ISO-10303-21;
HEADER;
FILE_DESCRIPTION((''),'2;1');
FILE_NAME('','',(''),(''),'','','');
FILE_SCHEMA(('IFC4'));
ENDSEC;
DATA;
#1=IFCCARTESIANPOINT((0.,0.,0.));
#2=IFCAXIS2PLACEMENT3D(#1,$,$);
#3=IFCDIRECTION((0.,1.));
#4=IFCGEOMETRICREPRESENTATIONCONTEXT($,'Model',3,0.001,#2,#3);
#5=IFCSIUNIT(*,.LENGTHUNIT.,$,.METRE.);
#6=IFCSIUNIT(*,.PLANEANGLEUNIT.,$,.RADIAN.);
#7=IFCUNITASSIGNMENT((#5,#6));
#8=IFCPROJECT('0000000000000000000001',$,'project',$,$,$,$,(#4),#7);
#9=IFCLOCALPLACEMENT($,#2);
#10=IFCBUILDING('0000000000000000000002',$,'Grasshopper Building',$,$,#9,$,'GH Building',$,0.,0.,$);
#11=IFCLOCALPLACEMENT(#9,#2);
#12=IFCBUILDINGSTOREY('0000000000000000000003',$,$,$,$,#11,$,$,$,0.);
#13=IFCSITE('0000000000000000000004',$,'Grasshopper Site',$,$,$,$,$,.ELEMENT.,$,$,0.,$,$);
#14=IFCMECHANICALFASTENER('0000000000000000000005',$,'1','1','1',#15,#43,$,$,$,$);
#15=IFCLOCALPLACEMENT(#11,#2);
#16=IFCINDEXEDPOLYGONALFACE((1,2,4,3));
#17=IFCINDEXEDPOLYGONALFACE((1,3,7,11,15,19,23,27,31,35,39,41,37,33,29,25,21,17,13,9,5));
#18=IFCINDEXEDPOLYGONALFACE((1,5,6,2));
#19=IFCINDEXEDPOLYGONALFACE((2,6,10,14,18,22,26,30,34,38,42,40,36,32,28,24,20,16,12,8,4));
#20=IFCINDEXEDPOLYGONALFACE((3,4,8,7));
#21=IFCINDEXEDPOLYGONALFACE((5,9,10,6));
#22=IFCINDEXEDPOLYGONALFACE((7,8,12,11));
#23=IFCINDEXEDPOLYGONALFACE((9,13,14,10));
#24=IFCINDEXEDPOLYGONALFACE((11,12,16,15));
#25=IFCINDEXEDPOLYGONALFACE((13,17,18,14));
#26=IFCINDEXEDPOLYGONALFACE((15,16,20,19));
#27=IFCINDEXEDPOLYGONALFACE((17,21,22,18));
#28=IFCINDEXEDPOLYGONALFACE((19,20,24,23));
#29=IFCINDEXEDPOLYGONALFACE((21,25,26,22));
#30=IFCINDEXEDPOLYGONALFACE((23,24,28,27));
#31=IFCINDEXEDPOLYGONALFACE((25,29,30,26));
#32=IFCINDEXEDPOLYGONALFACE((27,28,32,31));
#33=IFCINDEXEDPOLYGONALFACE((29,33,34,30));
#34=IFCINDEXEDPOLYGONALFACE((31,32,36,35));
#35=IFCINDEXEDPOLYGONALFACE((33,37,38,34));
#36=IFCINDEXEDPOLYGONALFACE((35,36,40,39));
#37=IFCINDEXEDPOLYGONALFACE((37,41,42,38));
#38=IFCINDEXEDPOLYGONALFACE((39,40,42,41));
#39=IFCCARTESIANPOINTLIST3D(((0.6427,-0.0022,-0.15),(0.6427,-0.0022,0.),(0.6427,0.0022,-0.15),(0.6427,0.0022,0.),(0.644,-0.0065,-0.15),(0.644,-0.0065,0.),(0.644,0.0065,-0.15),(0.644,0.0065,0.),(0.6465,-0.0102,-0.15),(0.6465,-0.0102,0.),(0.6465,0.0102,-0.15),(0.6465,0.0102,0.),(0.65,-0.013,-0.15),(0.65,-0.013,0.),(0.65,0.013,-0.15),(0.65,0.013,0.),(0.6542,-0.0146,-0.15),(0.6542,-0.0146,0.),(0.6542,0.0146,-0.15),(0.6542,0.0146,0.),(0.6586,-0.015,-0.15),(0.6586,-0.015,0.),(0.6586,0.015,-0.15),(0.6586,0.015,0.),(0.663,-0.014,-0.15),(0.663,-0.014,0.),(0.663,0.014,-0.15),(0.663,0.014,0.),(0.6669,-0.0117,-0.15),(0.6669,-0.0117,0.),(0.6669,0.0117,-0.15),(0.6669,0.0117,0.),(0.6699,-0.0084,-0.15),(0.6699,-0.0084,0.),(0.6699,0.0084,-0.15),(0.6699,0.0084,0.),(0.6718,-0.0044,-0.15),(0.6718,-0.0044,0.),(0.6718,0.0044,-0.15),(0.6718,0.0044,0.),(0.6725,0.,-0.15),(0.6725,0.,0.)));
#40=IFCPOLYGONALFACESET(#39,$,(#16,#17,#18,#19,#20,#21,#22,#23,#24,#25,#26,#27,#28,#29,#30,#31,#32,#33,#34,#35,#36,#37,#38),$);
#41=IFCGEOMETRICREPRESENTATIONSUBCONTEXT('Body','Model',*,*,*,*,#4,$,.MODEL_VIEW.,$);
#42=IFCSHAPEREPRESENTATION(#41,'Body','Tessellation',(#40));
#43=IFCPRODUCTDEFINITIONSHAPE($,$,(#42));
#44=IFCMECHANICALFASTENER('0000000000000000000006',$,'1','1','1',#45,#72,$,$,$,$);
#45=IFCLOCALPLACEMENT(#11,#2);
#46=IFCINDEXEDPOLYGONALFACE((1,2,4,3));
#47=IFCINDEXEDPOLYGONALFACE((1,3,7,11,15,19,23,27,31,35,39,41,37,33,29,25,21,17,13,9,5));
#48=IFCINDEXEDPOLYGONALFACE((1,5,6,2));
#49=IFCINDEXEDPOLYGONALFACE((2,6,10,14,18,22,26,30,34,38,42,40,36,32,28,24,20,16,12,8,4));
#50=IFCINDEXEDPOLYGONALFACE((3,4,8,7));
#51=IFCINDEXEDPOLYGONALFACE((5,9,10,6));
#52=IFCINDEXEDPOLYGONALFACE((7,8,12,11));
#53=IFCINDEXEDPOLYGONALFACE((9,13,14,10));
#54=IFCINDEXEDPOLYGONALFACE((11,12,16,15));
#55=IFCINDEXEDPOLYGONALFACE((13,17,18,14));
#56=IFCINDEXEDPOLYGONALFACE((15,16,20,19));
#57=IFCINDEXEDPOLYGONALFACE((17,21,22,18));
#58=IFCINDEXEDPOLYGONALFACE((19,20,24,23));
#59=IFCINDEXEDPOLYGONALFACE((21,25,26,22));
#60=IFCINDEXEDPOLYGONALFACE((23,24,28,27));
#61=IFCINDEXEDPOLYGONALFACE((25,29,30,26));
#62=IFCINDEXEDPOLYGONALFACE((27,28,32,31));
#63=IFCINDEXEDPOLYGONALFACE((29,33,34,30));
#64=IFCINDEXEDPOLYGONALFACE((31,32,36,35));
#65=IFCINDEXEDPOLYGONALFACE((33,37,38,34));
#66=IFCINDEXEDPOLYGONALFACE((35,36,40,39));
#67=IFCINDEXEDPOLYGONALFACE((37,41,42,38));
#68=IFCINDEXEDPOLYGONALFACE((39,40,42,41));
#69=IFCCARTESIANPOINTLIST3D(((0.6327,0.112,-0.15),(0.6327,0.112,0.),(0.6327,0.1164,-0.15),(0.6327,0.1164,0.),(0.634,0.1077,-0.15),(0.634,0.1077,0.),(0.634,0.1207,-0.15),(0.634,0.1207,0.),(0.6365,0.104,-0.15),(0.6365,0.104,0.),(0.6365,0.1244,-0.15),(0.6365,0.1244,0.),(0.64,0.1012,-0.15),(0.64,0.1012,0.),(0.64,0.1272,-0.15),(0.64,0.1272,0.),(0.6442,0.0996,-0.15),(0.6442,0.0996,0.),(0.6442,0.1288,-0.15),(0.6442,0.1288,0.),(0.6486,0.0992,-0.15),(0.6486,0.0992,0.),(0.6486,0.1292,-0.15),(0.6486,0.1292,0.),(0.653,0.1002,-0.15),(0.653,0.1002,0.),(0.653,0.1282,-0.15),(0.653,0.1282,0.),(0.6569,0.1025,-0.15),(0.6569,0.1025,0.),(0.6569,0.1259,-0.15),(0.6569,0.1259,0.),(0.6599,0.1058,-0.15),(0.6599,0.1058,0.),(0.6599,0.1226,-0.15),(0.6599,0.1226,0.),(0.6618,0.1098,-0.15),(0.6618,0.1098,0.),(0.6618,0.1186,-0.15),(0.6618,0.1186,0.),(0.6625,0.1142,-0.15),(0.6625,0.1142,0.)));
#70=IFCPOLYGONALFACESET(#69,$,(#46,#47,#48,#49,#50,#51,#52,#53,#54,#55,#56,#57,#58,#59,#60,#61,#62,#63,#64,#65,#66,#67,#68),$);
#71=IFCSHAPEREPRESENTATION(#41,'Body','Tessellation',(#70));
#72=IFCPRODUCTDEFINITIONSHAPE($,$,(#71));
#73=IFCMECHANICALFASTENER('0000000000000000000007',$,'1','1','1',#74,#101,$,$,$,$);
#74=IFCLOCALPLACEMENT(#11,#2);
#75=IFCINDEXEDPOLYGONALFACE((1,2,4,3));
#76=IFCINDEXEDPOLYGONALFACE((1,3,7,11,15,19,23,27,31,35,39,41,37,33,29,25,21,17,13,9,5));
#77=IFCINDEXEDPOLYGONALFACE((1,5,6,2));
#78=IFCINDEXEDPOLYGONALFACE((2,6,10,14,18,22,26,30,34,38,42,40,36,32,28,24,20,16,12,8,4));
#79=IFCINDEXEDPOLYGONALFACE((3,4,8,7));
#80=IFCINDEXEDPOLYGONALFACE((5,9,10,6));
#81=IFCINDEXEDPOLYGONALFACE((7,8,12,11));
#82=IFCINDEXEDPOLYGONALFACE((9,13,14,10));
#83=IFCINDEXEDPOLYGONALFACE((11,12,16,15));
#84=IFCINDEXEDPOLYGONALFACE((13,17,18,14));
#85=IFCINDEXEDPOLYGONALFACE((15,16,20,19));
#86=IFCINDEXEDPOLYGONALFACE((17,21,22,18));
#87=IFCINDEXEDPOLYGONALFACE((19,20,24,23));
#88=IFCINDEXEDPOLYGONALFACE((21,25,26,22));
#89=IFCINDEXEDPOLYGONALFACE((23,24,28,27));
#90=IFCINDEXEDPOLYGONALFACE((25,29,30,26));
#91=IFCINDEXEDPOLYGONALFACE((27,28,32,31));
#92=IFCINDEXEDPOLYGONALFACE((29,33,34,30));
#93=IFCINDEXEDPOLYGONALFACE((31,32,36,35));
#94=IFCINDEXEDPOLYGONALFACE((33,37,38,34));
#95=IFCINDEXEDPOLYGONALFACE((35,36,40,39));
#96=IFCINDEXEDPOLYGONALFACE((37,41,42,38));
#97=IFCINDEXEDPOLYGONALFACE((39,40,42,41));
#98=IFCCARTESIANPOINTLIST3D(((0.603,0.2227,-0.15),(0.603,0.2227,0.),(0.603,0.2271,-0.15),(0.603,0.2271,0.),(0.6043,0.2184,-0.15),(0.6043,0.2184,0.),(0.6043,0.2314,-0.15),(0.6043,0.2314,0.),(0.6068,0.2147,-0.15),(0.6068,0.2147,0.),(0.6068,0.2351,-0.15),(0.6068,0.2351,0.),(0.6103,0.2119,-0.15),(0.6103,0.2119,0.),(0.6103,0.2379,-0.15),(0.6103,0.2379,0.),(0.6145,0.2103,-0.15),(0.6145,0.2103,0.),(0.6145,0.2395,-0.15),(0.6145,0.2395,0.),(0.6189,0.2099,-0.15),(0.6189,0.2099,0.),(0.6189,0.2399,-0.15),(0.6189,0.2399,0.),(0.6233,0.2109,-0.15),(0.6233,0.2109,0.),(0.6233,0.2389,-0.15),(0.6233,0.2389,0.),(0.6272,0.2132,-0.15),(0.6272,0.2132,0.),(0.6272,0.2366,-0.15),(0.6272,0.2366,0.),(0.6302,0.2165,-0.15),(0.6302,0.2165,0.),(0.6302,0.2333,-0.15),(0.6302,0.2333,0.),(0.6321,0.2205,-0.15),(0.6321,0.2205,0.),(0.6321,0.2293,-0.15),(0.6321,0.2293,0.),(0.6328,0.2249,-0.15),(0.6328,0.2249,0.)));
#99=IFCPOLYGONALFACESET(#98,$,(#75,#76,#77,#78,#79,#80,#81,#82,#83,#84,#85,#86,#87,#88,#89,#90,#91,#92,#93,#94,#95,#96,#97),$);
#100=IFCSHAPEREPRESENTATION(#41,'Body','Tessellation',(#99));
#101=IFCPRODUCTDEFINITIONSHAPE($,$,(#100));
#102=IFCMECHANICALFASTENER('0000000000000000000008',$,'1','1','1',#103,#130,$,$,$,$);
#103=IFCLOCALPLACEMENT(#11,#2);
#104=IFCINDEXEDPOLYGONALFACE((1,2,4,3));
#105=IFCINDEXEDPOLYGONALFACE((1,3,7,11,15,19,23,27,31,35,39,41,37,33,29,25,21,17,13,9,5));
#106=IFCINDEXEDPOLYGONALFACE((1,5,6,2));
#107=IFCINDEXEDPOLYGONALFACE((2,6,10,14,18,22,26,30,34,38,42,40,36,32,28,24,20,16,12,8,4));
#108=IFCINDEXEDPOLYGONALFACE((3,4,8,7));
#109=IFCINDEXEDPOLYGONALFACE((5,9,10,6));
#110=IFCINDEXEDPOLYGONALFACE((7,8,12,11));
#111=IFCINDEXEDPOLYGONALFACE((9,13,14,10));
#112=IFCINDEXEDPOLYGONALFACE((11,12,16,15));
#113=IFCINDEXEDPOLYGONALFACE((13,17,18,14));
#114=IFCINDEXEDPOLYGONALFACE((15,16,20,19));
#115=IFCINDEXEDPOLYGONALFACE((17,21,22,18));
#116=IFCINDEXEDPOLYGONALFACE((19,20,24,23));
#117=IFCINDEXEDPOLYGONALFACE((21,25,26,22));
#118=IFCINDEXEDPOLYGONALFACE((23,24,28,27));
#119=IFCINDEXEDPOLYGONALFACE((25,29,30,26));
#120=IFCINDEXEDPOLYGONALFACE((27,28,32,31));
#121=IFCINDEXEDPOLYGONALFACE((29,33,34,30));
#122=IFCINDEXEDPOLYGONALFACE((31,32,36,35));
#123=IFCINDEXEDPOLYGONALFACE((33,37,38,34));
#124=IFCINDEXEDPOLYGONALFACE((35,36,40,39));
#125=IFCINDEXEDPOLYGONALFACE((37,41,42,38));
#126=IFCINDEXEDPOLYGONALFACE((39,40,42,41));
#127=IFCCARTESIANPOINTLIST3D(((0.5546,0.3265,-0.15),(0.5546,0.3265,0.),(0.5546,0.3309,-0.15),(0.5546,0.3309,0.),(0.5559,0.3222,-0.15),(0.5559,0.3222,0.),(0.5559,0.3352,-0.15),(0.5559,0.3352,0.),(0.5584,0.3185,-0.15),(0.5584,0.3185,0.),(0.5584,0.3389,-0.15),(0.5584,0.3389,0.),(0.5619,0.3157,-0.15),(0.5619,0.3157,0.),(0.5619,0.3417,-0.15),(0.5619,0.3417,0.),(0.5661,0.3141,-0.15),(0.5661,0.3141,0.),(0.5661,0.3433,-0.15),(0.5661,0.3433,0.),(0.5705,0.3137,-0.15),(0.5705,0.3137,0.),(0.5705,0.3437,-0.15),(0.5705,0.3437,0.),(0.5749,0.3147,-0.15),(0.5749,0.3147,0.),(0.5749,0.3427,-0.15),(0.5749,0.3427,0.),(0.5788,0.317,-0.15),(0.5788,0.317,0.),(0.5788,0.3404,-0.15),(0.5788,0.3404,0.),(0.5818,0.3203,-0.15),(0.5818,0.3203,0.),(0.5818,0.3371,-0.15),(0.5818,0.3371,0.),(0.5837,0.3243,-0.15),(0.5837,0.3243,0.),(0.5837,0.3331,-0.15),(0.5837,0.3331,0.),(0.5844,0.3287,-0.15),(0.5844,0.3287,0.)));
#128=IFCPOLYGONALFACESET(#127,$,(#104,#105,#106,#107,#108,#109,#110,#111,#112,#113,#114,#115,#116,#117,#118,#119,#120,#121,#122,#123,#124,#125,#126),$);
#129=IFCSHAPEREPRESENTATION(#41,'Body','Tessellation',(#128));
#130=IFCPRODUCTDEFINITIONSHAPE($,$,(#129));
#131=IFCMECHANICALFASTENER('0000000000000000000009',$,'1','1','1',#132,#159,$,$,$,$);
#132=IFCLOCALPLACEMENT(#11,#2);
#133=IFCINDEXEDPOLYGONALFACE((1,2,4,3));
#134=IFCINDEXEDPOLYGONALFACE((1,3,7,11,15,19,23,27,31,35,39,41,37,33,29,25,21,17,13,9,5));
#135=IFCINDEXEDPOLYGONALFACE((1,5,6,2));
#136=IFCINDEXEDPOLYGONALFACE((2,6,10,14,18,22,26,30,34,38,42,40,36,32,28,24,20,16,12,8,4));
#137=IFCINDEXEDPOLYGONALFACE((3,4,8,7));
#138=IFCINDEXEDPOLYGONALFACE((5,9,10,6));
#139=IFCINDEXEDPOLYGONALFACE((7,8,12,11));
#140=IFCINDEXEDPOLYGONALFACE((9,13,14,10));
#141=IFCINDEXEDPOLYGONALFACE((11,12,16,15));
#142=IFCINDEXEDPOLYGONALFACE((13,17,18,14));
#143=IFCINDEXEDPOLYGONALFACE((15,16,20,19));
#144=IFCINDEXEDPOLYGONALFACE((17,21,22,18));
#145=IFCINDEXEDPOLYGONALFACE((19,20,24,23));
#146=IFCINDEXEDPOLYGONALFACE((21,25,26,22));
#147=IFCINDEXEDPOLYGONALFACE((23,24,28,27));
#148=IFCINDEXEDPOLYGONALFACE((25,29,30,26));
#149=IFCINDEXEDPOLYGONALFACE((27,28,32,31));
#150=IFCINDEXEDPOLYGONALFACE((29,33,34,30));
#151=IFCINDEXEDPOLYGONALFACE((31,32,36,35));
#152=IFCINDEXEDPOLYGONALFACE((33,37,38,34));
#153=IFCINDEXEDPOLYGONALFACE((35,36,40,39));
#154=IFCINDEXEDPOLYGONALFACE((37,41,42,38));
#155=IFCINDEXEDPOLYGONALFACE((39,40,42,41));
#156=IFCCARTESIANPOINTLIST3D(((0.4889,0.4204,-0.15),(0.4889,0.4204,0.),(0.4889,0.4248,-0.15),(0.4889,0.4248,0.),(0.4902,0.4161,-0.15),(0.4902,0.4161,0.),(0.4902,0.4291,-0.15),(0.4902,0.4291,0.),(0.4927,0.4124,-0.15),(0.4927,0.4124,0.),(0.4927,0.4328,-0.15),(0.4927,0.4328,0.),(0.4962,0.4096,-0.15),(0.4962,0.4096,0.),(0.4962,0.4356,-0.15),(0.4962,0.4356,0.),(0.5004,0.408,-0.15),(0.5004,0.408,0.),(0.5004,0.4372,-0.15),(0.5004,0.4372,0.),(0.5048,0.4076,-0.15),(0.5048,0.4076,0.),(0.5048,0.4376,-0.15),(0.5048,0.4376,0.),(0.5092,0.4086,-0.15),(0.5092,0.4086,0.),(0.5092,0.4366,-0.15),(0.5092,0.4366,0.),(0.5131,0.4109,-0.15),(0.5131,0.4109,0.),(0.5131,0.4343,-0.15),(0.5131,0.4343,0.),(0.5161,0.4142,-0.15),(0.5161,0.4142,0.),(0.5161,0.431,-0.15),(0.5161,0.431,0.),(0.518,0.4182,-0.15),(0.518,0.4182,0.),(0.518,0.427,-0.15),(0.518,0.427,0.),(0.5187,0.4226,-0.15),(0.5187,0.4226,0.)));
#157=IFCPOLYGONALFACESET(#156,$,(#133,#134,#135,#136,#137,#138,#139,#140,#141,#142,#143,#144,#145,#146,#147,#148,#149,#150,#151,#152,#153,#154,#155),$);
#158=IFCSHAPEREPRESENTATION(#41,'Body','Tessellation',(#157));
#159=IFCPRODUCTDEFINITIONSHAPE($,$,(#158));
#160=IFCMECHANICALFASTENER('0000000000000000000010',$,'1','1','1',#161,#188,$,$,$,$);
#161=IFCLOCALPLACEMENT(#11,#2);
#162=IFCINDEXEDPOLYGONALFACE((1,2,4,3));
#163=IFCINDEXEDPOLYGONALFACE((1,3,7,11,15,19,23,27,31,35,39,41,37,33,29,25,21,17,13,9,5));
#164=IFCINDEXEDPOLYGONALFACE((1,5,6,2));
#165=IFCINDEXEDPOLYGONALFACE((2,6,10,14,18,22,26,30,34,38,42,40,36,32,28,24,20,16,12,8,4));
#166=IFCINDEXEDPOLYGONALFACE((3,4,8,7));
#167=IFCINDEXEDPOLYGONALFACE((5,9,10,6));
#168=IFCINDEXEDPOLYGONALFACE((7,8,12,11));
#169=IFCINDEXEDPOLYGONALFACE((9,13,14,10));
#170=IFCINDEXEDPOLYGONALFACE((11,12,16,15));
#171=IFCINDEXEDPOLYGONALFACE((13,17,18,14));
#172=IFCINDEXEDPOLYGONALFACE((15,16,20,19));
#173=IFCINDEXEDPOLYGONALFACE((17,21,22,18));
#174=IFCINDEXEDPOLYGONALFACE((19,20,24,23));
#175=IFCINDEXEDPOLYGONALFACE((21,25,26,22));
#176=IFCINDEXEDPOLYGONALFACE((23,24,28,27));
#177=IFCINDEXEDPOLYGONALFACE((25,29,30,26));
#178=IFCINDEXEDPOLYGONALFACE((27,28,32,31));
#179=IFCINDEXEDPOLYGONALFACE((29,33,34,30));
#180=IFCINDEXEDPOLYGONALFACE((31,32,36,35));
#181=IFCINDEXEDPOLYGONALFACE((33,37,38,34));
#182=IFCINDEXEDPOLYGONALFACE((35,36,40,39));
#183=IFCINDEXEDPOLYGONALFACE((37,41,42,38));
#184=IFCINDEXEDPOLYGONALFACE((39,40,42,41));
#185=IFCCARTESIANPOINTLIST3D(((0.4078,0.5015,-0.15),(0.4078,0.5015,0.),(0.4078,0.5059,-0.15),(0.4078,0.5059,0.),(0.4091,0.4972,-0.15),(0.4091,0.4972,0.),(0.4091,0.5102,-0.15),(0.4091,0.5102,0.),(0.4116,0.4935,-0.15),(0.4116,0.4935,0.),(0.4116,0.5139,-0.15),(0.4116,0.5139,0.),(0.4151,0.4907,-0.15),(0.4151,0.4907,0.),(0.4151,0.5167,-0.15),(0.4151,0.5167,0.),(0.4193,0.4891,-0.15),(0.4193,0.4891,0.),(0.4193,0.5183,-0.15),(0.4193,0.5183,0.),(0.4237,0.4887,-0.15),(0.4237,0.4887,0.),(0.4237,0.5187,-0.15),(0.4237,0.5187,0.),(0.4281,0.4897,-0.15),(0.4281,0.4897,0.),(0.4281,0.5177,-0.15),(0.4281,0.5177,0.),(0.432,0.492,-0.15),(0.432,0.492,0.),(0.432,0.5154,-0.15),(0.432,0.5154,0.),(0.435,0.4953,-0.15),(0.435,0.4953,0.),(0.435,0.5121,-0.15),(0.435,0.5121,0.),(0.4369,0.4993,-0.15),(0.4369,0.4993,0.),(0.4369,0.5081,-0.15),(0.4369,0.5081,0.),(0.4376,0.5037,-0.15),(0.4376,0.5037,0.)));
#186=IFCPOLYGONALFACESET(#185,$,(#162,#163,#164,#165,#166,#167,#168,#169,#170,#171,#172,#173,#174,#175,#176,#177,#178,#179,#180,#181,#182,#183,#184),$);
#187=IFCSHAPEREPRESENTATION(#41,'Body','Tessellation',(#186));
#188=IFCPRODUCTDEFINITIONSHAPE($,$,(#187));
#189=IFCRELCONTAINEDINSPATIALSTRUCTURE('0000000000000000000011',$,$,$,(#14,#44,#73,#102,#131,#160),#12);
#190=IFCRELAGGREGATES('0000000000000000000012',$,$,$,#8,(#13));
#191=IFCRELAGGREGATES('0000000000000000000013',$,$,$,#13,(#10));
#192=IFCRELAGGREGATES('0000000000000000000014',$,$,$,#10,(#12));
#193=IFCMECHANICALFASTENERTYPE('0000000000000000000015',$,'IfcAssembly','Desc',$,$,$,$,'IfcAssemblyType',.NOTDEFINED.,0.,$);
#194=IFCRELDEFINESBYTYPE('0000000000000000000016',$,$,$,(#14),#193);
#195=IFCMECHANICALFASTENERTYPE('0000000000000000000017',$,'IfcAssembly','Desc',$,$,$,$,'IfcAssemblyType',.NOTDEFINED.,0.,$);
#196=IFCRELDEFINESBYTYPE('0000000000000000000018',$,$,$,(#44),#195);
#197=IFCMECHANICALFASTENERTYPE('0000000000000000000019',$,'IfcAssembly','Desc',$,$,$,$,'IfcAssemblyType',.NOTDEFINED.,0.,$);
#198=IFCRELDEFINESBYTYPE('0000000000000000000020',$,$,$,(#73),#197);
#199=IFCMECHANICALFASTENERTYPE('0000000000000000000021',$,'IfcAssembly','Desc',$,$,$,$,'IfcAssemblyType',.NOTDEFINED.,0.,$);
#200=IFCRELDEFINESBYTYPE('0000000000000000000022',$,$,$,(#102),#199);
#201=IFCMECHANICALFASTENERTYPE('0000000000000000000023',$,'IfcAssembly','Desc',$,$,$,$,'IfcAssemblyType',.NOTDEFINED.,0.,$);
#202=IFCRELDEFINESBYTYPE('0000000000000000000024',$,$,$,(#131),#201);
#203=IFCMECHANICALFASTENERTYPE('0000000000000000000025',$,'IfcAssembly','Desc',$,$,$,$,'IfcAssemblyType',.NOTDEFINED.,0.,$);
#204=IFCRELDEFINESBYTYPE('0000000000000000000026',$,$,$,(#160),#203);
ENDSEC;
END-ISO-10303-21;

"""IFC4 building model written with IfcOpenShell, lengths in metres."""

from ifc_helpers import new_model, si_unit, direction, frame, origin, place, context, subcontext, project, spatial, circle, extrude, source, transform, mapped, type_object, type_shapes, element, save


model = new_model("IFC4")

# Units and contexts
model_context = context("Model", 3, precision=0.001, world=origin(), true_north=direction((0.0, 1.0)))
body_context = subcontext(model_context, "Body", "Model", "MODEL_VIEW")
ifc_project = project(units=[si_unit("LENGTHUNIT", "METRE"), si_unit("PLANEANGLEUNIT", "RADIAN")], contexts=[model_context])

# Site, building, storey
site = spatial("IfcSite", under=ifc_project, Name="Grasshopper Site", CompositionType="ELEMENT", RefElevation=0.0)
building_placement = place(None, origin())
building = spatial("IfcBuilding", under=site, at=building_placement, Name="Grasshopper Building", LongName="GH Building", ElevationOfRefHeight=0.0, ElevationOfTerrain=0.0)
storey_placement = place(building_placement, origin())
storey = spatial("IfcBuildingStorey", under=building, at=storey_placement, Elevation=0.0)

# Mechanical fasteners
mechanical_fastener_type_1 = type_object("IfcMechanicalFastenerType", Name="IfcAssembly", Description="Desc", ElementType="IfcAssemblyType", NominalDiameter=0.0)
shared_shape_1 = source(origin(), body_context, "Body", "SweptSolid", [
    extrude(circle(Radius=0.015), frame((0.6575, 0.0, 0.0), z_axis=(0.0, 0.0, -1.0), x_axis=(1.0, 0.0, 0.0)), (0.0, 0.0, 1.0), 0.15),
])
type_shapes(mechanical_fastener_type_1, [shared_shape_1])
mechanical_fastener_1_placement = place(storey_placement, origin())
element("IfcMechanicalFastener", 1, at=mechanical_fastener_1_placement, inside=storey, type_object=mechanical_fastener_type_1, Name="1", Description="1", ObjectType="1", context=body_context, shape_type="MappedRepresentation", body=[
    mapped(shared_shape_1, transform((0.0, 0.0, 0.0), scale=1.0)),
])
mechanical_fastener_type_2 = type_object("IfcMechanicalFastenerType", Name="IfcAssembly", Description="Desc", ElementType="IfcAssemblyType", NominalDiameter=0.0)
shared_shape_2 = source(origin(), body_context, "Body", "SweptSolid", [
    extrude(circle(Radius=0.015), frame((0.6475, 0.1142, 0.0), z_axis=(0.0, 0.0, -1.0), x_axis=(1.0, 0.0, 0.0)), (0.0, 0.0, 1.0), 0.15),
])
type_shapes(mechanical_fastener_type_2, [shared_shape_2])
mechanical_fastener_2_placement = place(storey_placement, origin())
element("IfcMechanicalFastener", 2, at=mechanical_fastener_2_placement, inside=storey, type_object=mechanical_fastener_type_2, Name="1", Description="1", ObjectType="1", context=body_context, shape_type="MappedRepresentation", body=[
    mapped(shared_shape_2, transform((0.0, 0.0, 0.0), scale=1.0)),
])
mechanical_fastener_type_3 = type_object("IfcMechanicalFastenerType", Name="IfcAssembly", Description="Desc", ElementType="IfcAssemblyType", NominalDiameter=0.0)
shared_shape_3 = source(origin(), body_context, "Body", "SweptSolid", [
    extrude(circle(Radius=0.015), frame((0.6178, 0.2249, 0.0), z_axis=(0.0, 0.0, -1.0), x_axis=(1.0, 0.0, 0.0)), (0.0, 0.0, 1.0), 0.15),
])
type_shapes(mechanical_fastener_type_3, [shared_shape_3])
mechanical_fastener_3_placement = place(storey_placement, origin())
element("IfcMechanicalFastener", 3, at=mechanical_fastener_3_placement, inside=storey, type_object=mechanical_fastener_type_3, Name="1", Description="1", ObjectType="1", context=body_context, shape_type="MappedRepresentation", body=[
    mapped(shared_shape_3, transform((0.0, 0.0, 0.0), scale=1.0)),
])
mechanical_fastener_type_4 = type_object("IfcMechanicalFastenerType", Name="IfcAssembly", Description="Desc", ElementType="IfcAssemblyType", NominalDiameter=0.0)
shared_shape_4 = source(origin(), body_context, "Body", "SweptSolid", [
    extrude(circle(Radius=0.015), frame((0.5694, 0.3287, 0.0), z_axis=(0.0, 0.0, -1.0), x_axis=(1.0, 0.0, 0.0)), (0.0, 0.0, 1.0), 0.15),
])
type_shapes(mechanical_fastener_type_4, [shared_shape_4])
mechanical_fastener_4_placement = place(storey_placement, origin())
element("IfcMechanicalFastener", 4, at=mechanical_fastener_4_placement, inside=storey, type_object=mechanical_fastener_type_4, Name="1", Description="1", ObjectType="1", context=body_context, shape_type="MappedRepresentation", body=[
    mapped(shared_shape_4, transform((0.0, 0.0, 0.0), scale=1.0)),
])
mechanical_fastener_type_5 = type_object("IfcMechanicalFastenerType", Name="IfcAssembly", Description="Desc", ElementType="IfcAssemblyType", NominalDiameter=0.0)
shared_shape_5 = source(origin(), body_context, "Body", "SweptSolid", [
    extrude(circle(Radius=0.015), frame((0.5037, 0.4226, 0.0), z_axis=(0.0, 0.0, -1.0), x_axis=(1.0, 0.0, 0.0)), (0.0, 0.0, 1.0), 0.15),
])
type_shapes(mechanical_fastener_type_5, [shared_shape_5])
mechanical_fastener_5_placement = place(storey_placement, origin())
element("IfcMechanicalFastener", 5, at=mechanical_fastener_5_placement, inside=storey, type_object=mechanical_fastener_type_5, Name="1", Description="1", ObjectType="1", context=body_context, shape_type="MappedRepresentation", body=[
    mapped(shared_shape_5, transform((0.0, 0.0, 0.0), scale=1.0)),
])
mechanical_fastener_type_6 = type_object("IfcMechanicalFastenerType", Name="IfcAssembly", Description="Desc", ElementType="IfcAssemblyType", NominalDiameter=0.0)
shared_shape_6 = source(origin(), body_context, "Body", "SweptSolid", [
    extrude(circle(Radius=0.015), frame((0.4226, 0.5037, 0.0), z_axis=(0.0, 0.0, -1.0), x_axis=(1.0, 0.0, 0.0)), (0.0, 0.0, 1.0), 0.15),
])
type_shapes(mechanical_fastener_type_6, [shared_shape_6])
mechanical_fastener_6_placement = place(storey_placement, origin())
element("IfcMechanicalFastener", 6, at=mechanical_fastener_6_placement, inside=storey, type_object=mechanical_fastener_type_6, Name="1", Description="1", ObjectType="1", context=body_context, shape_type="MappedRepresentation", body=[
    mapped(shared_shape_6, transform((0.0, 0.0, 0.0), scale=1.0)),
])

save(model, "model.ifc")
